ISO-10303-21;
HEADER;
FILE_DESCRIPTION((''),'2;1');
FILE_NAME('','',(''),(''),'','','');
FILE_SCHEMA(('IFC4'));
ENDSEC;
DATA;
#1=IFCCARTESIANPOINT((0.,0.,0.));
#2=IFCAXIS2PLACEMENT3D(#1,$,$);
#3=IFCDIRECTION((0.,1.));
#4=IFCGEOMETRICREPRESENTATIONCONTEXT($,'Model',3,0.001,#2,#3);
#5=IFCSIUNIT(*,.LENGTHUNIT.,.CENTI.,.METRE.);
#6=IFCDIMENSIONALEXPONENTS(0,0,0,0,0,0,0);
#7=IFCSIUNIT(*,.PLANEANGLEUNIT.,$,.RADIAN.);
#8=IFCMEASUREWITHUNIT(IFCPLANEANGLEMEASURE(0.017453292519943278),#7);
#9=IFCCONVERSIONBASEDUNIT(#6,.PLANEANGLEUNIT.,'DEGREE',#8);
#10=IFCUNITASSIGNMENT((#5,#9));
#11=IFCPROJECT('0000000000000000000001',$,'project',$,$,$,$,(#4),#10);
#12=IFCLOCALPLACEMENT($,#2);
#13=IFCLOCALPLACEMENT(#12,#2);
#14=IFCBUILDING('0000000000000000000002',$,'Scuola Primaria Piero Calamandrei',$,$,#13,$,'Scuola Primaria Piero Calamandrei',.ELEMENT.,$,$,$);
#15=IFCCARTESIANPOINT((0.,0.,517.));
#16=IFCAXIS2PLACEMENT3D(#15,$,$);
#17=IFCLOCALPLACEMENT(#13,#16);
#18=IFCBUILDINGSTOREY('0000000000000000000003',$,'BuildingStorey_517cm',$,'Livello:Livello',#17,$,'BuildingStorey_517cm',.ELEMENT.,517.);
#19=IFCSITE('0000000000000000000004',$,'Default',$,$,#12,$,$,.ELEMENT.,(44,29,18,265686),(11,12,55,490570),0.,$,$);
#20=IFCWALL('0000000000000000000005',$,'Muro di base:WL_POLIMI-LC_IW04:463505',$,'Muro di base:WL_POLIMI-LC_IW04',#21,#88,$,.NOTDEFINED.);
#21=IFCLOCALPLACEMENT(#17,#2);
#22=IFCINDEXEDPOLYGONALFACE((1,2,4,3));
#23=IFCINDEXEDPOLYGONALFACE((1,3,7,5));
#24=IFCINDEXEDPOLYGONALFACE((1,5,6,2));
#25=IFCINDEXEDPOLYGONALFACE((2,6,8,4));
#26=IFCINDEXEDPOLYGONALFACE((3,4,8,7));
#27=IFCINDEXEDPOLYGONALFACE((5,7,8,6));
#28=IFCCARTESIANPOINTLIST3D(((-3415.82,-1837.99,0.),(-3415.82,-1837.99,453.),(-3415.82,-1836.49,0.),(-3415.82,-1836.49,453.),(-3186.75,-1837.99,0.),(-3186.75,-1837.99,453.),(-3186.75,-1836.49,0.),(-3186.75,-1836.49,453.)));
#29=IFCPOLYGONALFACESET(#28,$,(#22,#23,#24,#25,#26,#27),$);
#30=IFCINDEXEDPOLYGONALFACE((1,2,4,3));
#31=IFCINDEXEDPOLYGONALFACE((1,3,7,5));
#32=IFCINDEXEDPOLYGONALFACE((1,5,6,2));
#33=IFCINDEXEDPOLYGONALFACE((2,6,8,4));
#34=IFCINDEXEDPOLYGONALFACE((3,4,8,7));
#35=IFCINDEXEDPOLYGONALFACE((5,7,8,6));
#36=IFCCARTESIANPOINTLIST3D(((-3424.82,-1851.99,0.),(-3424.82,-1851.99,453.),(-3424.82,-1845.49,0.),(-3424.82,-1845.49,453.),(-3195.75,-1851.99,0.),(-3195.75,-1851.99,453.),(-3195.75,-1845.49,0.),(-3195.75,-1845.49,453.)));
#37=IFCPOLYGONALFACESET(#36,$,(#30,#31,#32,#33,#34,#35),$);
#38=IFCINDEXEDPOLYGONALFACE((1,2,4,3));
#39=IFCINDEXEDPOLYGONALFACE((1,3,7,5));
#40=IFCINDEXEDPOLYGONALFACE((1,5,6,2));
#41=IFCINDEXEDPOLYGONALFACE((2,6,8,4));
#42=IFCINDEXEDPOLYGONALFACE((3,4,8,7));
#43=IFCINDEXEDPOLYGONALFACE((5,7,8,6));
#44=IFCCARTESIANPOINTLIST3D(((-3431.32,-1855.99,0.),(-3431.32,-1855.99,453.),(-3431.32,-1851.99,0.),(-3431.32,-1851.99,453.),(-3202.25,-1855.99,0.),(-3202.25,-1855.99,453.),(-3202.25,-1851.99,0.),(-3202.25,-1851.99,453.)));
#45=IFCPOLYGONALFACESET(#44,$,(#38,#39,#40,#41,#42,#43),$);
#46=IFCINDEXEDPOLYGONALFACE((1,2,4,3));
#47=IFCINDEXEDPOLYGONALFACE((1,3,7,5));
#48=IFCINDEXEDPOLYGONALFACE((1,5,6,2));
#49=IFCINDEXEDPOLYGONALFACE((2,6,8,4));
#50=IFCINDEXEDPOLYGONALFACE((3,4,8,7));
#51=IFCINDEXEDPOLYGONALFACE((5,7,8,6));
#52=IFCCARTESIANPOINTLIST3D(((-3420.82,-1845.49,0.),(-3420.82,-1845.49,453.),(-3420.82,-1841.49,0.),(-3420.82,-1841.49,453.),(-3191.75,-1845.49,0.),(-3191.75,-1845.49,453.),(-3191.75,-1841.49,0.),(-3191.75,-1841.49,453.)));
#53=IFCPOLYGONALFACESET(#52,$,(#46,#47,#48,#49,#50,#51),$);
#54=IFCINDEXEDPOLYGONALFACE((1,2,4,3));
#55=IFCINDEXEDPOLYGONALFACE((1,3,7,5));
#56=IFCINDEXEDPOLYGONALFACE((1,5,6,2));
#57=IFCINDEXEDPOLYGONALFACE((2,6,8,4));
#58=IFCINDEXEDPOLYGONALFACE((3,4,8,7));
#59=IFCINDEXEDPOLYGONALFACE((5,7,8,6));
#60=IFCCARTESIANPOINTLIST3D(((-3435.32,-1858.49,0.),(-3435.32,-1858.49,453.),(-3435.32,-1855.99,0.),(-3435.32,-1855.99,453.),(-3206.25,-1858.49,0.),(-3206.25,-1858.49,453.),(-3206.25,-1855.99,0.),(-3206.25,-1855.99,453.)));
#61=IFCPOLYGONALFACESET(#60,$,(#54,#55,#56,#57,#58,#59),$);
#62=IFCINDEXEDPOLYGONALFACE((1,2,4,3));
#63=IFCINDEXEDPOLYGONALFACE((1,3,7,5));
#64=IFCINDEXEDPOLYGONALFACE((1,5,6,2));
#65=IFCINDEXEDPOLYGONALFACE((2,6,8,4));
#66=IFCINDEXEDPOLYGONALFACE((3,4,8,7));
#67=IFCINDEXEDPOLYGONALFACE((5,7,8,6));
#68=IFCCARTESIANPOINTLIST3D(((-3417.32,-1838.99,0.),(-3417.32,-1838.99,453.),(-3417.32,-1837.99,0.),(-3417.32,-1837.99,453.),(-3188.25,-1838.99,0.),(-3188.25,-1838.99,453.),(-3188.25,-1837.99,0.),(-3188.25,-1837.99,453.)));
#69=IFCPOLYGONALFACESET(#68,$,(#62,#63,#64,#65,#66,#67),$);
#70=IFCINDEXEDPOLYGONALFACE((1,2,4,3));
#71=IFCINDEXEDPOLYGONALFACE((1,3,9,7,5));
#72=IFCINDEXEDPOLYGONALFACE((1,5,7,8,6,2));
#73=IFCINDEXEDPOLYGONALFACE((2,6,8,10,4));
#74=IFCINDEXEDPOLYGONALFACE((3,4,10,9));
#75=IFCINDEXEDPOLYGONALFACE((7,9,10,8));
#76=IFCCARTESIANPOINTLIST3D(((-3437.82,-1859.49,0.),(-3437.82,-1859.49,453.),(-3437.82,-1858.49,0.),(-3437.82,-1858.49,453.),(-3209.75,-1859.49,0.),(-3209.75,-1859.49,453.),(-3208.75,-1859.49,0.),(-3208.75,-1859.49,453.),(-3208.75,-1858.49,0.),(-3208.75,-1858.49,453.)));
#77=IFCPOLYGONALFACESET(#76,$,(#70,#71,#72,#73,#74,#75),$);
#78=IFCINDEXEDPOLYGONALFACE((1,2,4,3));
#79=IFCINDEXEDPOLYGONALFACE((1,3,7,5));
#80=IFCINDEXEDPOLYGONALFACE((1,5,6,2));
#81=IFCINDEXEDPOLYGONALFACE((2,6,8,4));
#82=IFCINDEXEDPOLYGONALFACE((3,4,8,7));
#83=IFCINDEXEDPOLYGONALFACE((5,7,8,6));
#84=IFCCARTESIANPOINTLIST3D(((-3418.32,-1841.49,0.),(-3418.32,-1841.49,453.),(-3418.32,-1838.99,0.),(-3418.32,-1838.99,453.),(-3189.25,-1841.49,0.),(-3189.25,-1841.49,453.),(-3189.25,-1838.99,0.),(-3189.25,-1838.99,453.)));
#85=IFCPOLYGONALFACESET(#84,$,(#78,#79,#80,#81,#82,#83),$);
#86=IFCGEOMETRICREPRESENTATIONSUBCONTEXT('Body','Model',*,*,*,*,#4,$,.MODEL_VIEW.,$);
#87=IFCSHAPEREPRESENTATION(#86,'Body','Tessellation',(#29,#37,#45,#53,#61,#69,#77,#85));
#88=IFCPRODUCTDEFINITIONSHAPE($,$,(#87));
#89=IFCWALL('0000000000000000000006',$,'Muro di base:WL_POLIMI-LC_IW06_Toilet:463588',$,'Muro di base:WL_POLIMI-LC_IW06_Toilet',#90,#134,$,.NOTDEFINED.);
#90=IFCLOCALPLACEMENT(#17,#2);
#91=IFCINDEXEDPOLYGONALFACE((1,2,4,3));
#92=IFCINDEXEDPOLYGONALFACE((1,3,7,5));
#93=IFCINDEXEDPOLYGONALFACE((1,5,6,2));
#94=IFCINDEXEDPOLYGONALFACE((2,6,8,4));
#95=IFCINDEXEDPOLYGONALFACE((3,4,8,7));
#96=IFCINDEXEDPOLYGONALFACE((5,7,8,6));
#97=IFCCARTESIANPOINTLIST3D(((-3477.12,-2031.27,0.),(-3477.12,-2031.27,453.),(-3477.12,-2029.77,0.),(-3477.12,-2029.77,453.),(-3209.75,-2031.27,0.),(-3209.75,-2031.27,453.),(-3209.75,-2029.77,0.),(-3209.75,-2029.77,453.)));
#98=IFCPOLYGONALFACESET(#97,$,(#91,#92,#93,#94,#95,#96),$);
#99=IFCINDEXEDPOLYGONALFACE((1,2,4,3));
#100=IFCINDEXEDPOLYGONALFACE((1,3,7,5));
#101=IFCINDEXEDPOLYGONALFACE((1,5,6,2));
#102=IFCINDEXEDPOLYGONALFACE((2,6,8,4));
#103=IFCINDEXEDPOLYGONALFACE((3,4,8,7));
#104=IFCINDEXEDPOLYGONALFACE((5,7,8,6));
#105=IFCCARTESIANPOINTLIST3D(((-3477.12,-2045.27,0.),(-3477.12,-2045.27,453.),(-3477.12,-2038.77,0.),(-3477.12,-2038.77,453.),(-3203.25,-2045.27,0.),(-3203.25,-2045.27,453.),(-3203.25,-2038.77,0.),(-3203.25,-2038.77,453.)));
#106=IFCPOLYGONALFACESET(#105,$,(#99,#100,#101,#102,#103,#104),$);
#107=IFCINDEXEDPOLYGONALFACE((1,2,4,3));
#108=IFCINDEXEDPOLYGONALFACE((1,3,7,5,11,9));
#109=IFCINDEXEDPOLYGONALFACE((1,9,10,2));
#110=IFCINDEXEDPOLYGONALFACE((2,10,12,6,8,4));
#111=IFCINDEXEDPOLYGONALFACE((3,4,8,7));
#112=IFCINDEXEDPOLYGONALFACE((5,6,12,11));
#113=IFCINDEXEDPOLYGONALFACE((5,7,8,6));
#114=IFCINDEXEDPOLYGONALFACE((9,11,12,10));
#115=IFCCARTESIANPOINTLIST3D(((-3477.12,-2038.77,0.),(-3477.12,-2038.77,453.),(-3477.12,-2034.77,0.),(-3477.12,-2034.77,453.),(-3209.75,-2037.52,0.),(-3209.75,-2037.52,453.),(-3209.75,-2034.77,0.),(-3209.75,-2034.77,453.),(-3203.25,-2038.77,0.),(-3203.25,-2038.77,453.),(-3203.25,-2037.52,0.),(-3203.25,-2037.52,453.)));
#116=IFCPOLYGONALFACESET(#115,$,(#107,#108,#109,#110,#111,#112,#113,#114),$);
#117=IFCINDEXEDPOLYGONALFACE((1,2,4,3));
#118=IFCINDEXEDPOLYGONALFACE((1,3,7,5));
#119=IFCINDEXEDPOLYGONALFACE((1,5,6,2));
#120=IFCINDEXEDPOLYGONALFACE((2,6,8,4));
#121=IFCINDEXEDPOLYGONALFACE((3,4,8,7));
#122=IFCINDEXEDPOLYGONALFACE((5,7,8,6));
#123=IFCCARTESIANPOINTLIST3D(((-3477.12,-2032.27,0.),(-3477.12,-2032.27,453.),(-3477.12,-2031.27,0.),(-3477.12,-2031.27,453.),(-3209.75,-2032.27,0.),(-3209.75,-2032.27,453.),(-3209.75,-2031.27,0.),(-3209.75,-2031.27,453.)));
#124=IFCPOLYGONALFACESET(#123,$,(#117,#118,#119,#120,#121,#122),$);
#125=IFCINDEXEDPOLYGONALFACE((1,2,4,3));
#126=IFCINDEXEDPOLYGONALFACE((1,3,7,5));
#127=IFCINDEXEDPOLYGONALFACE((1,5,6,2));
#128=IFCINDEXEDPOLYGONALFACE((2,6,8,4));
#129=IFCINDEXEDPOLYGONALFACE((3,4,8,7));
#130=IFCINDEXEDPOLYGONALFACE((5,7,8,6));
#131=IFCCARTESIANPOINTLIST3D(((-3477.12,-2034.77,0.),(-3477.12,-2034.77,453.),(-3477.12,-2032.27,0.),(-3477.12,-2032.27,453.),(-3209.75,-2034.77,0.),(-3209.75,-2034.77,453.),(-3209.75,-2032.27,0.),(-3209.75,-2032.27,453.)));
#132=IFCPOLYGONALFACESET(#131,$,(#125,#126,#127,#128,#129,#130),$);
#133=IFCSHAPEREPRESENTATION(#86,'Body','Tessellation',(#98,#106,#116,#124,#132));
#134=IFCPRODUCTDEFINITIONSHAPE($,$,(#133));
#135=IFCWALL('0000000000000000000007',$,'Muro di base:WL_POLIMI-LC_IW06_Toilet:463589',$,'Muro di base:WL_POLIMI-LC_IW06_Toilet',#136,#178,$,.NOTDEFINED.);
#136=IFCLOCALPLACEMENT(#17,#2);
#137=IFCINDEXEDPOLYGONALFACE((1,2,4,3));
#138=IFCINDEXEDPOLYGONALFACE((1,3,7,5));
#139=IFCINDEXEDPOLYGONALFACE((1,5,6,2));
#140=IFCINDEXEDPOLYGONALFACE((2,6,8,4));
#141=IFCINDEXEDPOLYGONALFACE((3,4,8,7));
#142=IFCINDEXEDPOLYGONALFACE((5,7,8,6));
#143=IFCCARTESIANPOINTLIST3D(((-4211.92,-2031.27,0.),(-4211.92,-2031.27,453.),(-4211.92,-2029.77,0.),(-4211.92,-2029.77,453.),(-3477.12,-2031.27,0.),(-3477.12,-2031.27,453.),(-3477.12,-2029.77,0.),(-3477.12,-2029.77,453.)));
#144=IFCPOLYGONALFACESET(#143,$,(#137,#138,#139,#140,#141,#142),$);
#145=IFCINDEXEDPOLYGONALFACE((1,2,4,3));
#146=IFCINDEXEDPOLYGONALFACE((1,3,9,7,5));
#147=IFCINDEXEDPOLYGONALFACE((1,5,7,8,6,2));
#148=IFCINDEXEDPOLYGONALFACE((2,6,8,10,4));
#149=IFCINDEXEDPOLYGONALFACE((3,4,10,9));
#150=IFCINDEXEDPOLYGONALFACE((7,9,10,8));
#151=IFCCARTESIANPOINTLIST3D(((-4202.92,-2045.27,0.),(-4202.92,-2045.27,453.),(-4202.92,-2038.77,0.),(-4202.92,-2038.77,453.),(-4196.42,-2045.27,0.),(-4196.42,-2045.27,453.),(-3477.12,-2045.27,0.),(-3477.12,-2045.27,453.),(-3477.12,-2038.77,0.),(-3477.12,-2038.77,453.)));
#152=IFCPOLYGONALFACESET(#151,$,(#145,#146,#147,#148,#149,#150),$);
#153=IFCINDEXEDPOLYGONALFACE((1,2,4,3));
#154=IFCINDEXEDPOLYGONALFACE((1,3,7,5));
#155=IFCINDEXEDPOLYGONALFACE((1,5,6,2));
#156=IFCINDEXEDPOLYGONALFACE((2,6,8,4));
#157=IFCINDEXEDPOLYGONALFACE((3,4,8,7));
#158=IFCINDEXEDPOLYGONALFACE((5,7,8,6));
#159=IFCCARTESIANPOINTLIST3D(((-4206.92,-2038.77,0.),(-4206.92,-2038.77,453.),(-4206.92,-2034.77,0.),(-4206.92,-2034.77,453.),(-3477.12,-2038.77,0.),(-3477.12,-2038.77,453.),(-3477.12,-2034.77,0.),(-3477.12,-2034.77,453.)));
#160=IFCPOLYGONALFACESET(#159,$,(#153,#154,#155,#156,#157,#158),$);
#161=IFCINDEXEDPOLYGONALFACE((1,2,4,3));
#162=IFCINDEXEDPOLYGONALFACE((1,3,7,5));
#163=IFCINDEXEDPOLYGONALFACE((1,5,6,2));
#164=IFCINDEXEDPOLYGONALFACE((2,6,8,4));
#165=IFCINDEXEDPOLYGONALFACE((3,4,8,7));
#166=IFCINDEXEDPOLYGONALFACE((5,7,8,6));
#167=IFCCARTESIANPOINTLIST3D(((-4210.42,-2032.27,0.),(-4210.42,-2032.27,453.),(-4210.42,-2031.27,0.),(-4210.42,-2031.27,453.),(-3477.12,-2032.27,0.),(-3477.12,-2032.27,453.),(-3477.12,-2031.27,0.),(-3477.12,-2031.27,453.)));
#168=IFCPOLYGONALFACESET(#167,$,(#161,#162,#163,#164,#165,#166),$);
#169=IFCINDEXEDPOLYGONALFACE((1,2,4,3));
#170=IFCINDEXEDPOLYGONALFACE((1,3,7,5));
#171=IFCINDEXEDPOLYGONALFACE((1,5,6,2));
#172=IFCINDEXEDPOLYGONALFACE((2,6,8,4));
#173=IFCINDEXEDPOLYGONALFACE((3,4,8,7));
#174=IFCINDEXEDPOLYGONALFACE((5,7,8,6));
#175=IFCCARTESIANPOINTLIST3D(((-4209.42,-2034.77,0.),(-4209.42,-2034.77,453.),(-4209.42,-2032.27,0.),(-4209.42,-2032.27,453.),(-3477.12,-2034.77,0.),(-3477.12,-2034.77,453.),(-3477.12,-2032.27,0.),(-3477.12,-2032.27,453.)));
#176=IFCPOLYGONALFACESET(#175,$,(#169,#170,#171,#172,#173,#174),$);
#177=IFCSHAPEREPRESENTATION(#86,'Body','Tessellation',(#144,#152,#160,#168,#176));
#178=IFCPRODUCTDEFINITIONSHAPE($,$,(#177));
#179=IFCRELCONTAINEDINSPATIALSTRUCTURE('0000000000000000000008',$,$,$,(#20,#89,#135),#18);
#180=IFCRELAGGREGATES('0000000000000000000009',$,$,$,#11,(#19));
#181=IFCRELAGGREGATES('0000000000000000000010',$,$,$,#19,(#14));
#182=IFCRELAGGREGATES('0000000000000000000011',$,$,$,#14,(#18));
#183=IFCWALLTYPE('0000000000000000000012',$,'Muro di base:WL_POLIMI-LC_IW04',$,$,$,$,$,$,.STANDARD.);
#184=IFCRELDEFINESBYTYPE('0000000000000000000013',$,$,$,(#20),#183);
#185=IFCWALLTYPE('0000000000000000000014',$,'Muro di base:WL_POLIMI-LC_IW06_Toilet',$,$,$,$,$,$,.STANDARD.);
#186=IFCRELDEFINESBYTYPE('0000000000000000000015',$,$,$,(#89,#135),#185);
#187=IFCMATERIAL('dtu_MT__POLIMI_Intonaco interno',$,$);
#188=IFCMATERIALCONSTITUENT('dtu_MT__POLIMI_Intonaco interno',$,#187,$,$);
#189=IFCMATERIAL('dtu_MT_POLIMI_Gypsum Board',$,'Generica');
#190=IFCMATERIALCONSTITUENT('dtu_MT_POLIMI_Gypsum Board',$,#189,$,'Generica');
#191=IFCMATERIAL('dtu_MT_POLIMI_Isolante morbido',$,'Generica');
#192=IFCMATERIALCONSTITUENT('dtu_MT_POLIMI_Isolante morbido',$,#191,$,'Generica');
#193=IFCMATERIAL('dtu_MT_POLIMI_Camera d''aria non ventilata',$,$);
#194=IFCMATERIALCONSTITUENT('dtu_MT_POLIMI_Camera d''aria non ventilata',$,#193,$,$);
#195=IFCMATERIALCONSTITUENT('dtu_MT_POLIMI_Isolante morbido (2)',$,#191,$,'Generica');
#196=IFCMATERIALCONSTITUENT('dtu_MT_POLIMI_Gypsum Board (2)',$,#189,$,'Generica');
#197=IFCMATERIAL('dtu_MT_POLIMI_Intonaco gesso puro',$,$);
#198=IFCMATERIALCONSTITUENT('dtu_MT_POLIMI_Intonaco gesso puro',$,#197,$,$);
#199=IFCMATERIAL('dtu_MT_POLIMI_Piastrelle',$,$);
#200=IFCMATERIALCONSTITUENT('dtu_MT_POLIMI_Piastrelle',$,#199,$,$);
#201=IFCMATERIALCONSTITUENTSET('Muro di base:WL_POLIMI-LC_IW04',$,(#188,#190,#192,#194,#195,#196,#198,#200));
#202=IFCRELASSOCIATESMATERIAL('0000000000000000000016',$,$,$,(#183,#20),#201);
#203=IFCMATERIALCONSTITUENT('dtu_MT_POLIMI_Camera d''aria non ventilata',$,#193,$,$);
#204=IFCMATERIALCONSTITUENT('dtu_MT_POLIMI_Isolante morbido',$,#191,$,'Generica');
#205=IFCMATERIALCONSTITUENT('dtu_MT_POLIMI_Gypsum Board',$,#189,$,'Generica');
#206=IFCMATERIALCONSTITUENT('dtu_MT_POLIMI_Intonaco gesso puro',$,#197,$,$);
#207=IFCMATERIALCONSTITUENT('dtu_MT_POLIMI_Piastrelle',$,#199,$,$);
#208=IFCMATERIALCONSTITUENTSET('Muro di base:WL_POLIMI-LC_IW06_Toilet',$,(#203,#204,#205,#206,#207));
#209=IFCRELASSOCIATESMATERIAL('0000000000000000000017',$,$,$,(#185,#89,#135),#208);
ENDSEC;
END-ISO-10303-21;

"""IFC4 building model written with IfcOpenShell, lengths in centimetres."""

from ifc_helpers import new_model, entity, si_unit, converted_unit, direction, frame, origin, place, context, subcontext, project, spatial, indexed_curve, outline, extrude, material, constituent, constituent_set, type_object, element, save


model = new_model("IFC4")

# Units and contexts
model_context = context("Model", 3, precision=0.001, world=origin(), true_north=direction((0.0, 1.0)))
body_context = subcontext(model_context, "Body", "Model", "MODEL_VIEW")
ifc_project = project(units=[si_unit("LENGTHUNIT", "METRE", prefix="CENTI"), converted_unit("PLANEANGLEUNIT", "DEGREE", entity("IfcPlaneAngleMeasure", 0.017453292519943278), si_unit("PLANEANGLEUNIT", "RADIAN"), dimensions=[0, 0, 0, 0, 0, 0, 0])], contexts=[model_context])

# Site, building, storey
site_placement = place(None, origin())
site = spatial("IfcSite", under=ifc_project, at=site_placement, Name="Default", CompositionType="ELEMENT", RefLatitude=(44, 29, 18, 265686), RefLongitude=(11, 12, 55, 490570), RefElevation=0.0)
building_placement = place(site_placement, origin())
building = spatial("IfcBuilding", under=site, at=building_placement, Name="Scuola Primaria Piero Calamandrei", LongName="Scuola Primaria Piero Calamandrei", CompositionType="ELEMENT")
storey_placement = place(building_placement, frame((0.0, 0.0, 517.0)))
storey = spatial("IfcBuildingStorey", under=building, at=storey_placement, Name="BuildingStorey_517cm", ObjectType="Livello:Livello", LongName="BuildingStorey_517cm", CompositionType="ELEMENT", Elevation=517.0)

# Shared definitions
ifc_material_1 = material(Name="dtu_MT_POLIMI_Isolante morbido", Category="Generica")
ifc_material_2 = material(Name="dtu_MT_POLIMI_Gypsum Board", Category="Generica")
ifc_material_3 = material(Name="dtu_MT__POLIMI_Intonaco interno")

# Shared definitions
ifc_material_4 = material(Name="dtu_MT_POLIMI_Camera d'aria non ventilata")
ifc_material_5 = material(Name="dtu_MT_POLIMI_Intonaco gesso puro")

# Walls
ifc_constituent_1 = constituent(ifc_material_3, Name="dtu_MT__POLIMI_Intonaco interno")
ifc_constituent_2 = constituent(ifc_material_2, Name="dtu_MT_POLIMI_Gypsum Board", Category="Generica")
ifc_constituent_3 = constituent(ifc_material_1, Name="dtu_MT_POLIMI_Isolante morbido", Category="Generica")
ifc_constituent_4 = constituent(ifc_material_4, Name="dtu_MT_POLIMI_Camera d'aria non ventilata")
ifc_constituent_5 = constituent(ifc_material_1, Name="dtu_MT_POLIMI_Isolante morbido (2)", Category="Generica")
ifc_constituent_6 = constituent(ifc_material_2, Name="dtu_MT_POLIMI_Gypsum Board (2)", Category="Generica")
ifc_constituent_7 = constituent(ifc_material_5, Name="dtu_MT_POLIMI_Intonaco gesso puro")
ifc_material_6 = material(Name="dtu_MT_POLIMI_Piastrelle")
ifc_constituent_8 = constituent(ifc_material_6, Name="dtu_MT_POLIMI_Piastrelle")
ifc_constituent_set_1 = constituent_set(constituents=[ifc_constituent_1, ifc_constituent_2, ifc_constituent_3, ifc_constituent_4, ifc_constituent_5, ifc_constituent_6, ifc_constituent_7, ifc_constituent_8], Name="Muro di base:WL_POLIMI-LC_IW04")
wall_type_1 = type_object("IfcWallType", Name="Muro di base:WL_POLIMI-LC_IW04", PredefinedType="STANDARD", material=ifc_constituent_set_1)
wall_1_placement = place(storey_placement, frame((-3186.75, -1847.99, 0.0), z_axis=(0.0, 0.0, 1.0), x_axis=(-1.0, 0.0, 0.0)))
element("IfcWall", 1, at=wall_1_placement, inside=storey, type_object=wall_type_1, material=ifc_constituent_set_1, Name="Muro di base:WL_POLIMI-LC_IW04:463505", ObjectType="Muro di base:WL_POLIMI-LC_IW04", PredefinedType="NOTDEFINED", context=body_context, shape_type="SweptSolid", body=[
    extrude(outline(indexed_curve([(-0.75, -114.54), (0.75, -114.54), (0.75, 114.54), (-0.75, 114.54), (-0.75, -114.54)], self_intersect=False)), frame((114.54, -10.75, 0.0), z_axis=(0.0, 0.0, 1.0), x_axis=(0.0, 1.0, 0.0)), (0.0, 0.0, 1.0), 453.0),
    extrude(outline(indexed_curve([(-114.54, -3.25), (114.54, -3.25), (114.54, 3.25), (-114.54, 3.25), (-114.54, -3.25)], self_intersect=False)), frame((123.54, 0.75, 0.0)), (0.0, 0.0, 1.0), 453.0),
    extrude(outline(indexed_curve([(-114.54, -2.0), (114.54, -2.0), (114.54, 2.0), (-114.54, 2.0), (-114.54, -2.0)], self_intersect=False)), frame((130.04, 6.0, 0.0)), (0.0, 0.0, 1.0), 453.0),
    extrude(outline(indexed_curve([(-114.54, -2.0), (114.54, -2.0), (114.54, 2.0), (-114.54, 2.0), (-114.54, -2.0)], self_intersect=False)), frame((119.54, -4.5, 0.0)), (0.0, 0.0, 1.0), 453.0),
    extrude(outline(indexed_curve([(-114.54, -1.25), (114.54, -1.25), (114.54, 1.25), (-114.54, 1.25), (-114.54, -1.25)], self_intersect=False)), frame((134.04, 9.25, 0.0)), (0.0, 0.0, 1.0), 453.0),
    extrude(outline(indexed_curve([(-114.54, -0.5), (114.54, -0.5), (114.54, 0.5), (-114.54, 0.5), (-114.54, -0.5)], self_intersect=False)), frame((116.04, -9.5, 0.0)), (0.0, 0.0, 1.0), 453.0),
    extrude(outline(indexed_curve([(90.83, -0.4), (91.83, -0.4), (91.83, 0.6), (-137.24, 0.6), (-137.24, -0.4), (90.83, -0.4)], self_intersect=False)), frame((113.83, 11.1, 0.0), z_axis=(0.0, 0.0, 1.0), x_axis=(-1.0, 0.0, 0.0)), (0.0, 0.0, 1.0), 453.0),
    extrude(outline(indexed_curve([(-114.54, -1.25), (114.54, -1.25), (114.54, 1.25), (-114.54, 1.25), (-114.54, -1.25)], self_intersect=False)), frame((117.04, -7.75, 0.0)), (0.0, 0.0, 1.0), 453.0),
])
ifc_constituent_9 = constituent(ifc_material_4, Name="dtu_MT_POLIMI_Camera d'aria non ventilata")
ifc_constituent_10 = constituent(ifc_material_1, Name="dtu_MT_POLIMI_Isolante morbido", Category="Generica")
ifc_constituent_11 = constituent(ifc_material_2, Name="dtu_MT_POLIMI_Gypsum Board", Category="Generica")
ifc_constituent_12 = constituent(ifc_material_5, Name="dtu_MT_POLIMI_Intonaco gesso puro")
ifc_constituent_13 = constituent(ifc_material_6, Name="dtu_MT_POLIMI_Piastrelle")
ifc_constituent_set_2 = constituent_set(constituents=[ifc_constituent_9, ifc_constituent_10, ifc_constituent_11, ifc_constituent_12, ifc_constituent_13], Name="Muro di base:WL_POLIMI-LC_IW06_Toilet")
wall_type_2 = type_object("IfcWallType", Name="Muro di base:WL_POLIMI-LC_IW06_Toilet", PredefinedType="STANDARD", material=ifc_constituent_set_2)
wall_2_placement = place(storey_placement, frame((-3203.25, -2037.52, 0.0), z_axis=(0.0, 0.0, 1.0), x_axis=(-1.0, 0.0, 0.0)))
element("IfcWall", 2, at=wall_2_placement, inside=storey, type_object=wall_type_2, material=ifc_constituent_set_2, Name="Muro di base:WL_POLIMI-LC_IW06_Toilet:463588", ObjectType="Muro di base:WL_POLIMI-LC_IW06_Toilet", PredefinedType="NOTDEFINED", context=body_context, shape_type="SweptSolid", body=[
    extrude(outline(indexed_curve([(-0.75, -133.68), (0.75, -133.68), (0.75, 133.68), (-0.75, 133.68), (-0.75, -133.68)], self_intersect=False)), frame((140.18, -7.0, 0.0), z_axis=(0.0, 0.0, 1.0), x_axis=(0.0, 1.0, 0.0)), (0.0, 0.0, 1.0), 453.0),
    extrude(outline(indexed_curve([(-3.25, -136.93), (3.25, -136.93), (3.25, 136.93), (-3.25, 136.93), (-3.25, -136.93)], self_intersect=False)), frame((136.93, 4.5, 0.0), z_axis=(0.0, 0.0, 1.0), x_axis=(0.0, -1.0, 0.0)), (0.0, 0.0, 1.0), 453.0),
    extrude(outline(indexed_curve([(-0.5, -86.96), (2.25, -86.96), (2.25, 180.41), (-1.75, 180.41), (-1.75, -93.46), (-0.5, -93.46), (-0.5, -86.96)], self_intersect=False)), frame((93.46, -0.5, 0.0), z_axis=(0.0, 0.0, 1.0), x_axis=(0.0, -1.0, 0.0)), (0.0, 0.0, 1.0), 453.0),
    extrude(outline(indexed_curve([(-133.68, -0.5), (133.68, -0.5), (133.68, 0.5), (-133.68, 0.5), (-133.68, -0.5)], self_intersect=False)), frame((140.18, -5.75, 0.0)), (0.0, 0.0, 1.0), 453.0),
    extrude(outline(indexed_curve([(-133.68, -1.25), (133.68, -1.25), (133.68, 1.25), (-133.68, 1.25), (-133.68, -1.25)], self_intersect=False)), frame((140.18, -4.0, 0.0)), (0.0, 0.0, 1.0), 453.0),
])
wall_3_placement = place(storey_placement, frame((-3477.12, -2037.52, 0.0), z_axis=(0.0, 0.0, 1.0), x_axis=(-1.0, 0.0, 0.0)))
element("IfcWall", 3, at=wall_3_placement, inside=storey, type_object=wall_type_2, material=ifc_constituent_set_2, Name="Muro di base:WL_POLIMI-LC_IW06_Toilet:463589", ObjectType="Muro di base:WL_POLIMI-LC_IW06_Toilet", PredefinedType="NOTDEFINED", context=body_context, shape_type="SweptSolid", body=[
    extrude(outline(indexed_curve([(-0.75, -367.4), (0.75, -367.4), (0.75, 367.4), (-0.75, 367.4), (-0.75, -367.4)], self_intersect=False)), frame((367.4, -7.0, 0.0), z_axis=(0.0, 0.0, 1.0), x_axis=(0.0, 1.0, 0.0)), (0.0, 0.0, 1.0), 453.0),
    extrude(outline(indexed_curve([(-285.12, -2.6), (434.18, -2.6), (434.18, 3.9), (-291.62, 3.9), (-291.62, -2.6), (-285.12, -2.6)], self_intersect=False)), frame((434.18, 5.15, 0.0), z_axis=(0.0, 0.0, 1.0), x_axis=(-1.0, 0.0, 0.0)), (0.0, 0.0, 1.0), 453.0),
    extrude(outline(indexed_curve([(-364.9, -2.0), (364.9, -2.0), (364.9, 2.0), (-364.9, 2.0), (-364.9, -2.0)], self_intersect=False)), frame((364.9, -0.75, 0.0)), (0.0, 0.0, 1.0), 453.0),
    extrude(outline(indexed_curve([(-366.65, -0.5), (366.65, -0.5), (366.65, 0.5), (-366.65, 0.5), (-366.65, -0.5)], self_intersect=False)), frame((366.65, -5.75, 0.0)), (0.0, 0.0, 1.0), 453.0),
    extrude(outline(indexed_curve([(-366.15, -1.25), (366.15, -1.25), (366.15, 1.25), (-366.15, 1.25), (-366.15, -1.25)], self_intersect=False)), frame((366.15, -4.0, 0.0)), (0.0, 0.0, 1.0), 453.0),
])

save(model, "model.ifc")
